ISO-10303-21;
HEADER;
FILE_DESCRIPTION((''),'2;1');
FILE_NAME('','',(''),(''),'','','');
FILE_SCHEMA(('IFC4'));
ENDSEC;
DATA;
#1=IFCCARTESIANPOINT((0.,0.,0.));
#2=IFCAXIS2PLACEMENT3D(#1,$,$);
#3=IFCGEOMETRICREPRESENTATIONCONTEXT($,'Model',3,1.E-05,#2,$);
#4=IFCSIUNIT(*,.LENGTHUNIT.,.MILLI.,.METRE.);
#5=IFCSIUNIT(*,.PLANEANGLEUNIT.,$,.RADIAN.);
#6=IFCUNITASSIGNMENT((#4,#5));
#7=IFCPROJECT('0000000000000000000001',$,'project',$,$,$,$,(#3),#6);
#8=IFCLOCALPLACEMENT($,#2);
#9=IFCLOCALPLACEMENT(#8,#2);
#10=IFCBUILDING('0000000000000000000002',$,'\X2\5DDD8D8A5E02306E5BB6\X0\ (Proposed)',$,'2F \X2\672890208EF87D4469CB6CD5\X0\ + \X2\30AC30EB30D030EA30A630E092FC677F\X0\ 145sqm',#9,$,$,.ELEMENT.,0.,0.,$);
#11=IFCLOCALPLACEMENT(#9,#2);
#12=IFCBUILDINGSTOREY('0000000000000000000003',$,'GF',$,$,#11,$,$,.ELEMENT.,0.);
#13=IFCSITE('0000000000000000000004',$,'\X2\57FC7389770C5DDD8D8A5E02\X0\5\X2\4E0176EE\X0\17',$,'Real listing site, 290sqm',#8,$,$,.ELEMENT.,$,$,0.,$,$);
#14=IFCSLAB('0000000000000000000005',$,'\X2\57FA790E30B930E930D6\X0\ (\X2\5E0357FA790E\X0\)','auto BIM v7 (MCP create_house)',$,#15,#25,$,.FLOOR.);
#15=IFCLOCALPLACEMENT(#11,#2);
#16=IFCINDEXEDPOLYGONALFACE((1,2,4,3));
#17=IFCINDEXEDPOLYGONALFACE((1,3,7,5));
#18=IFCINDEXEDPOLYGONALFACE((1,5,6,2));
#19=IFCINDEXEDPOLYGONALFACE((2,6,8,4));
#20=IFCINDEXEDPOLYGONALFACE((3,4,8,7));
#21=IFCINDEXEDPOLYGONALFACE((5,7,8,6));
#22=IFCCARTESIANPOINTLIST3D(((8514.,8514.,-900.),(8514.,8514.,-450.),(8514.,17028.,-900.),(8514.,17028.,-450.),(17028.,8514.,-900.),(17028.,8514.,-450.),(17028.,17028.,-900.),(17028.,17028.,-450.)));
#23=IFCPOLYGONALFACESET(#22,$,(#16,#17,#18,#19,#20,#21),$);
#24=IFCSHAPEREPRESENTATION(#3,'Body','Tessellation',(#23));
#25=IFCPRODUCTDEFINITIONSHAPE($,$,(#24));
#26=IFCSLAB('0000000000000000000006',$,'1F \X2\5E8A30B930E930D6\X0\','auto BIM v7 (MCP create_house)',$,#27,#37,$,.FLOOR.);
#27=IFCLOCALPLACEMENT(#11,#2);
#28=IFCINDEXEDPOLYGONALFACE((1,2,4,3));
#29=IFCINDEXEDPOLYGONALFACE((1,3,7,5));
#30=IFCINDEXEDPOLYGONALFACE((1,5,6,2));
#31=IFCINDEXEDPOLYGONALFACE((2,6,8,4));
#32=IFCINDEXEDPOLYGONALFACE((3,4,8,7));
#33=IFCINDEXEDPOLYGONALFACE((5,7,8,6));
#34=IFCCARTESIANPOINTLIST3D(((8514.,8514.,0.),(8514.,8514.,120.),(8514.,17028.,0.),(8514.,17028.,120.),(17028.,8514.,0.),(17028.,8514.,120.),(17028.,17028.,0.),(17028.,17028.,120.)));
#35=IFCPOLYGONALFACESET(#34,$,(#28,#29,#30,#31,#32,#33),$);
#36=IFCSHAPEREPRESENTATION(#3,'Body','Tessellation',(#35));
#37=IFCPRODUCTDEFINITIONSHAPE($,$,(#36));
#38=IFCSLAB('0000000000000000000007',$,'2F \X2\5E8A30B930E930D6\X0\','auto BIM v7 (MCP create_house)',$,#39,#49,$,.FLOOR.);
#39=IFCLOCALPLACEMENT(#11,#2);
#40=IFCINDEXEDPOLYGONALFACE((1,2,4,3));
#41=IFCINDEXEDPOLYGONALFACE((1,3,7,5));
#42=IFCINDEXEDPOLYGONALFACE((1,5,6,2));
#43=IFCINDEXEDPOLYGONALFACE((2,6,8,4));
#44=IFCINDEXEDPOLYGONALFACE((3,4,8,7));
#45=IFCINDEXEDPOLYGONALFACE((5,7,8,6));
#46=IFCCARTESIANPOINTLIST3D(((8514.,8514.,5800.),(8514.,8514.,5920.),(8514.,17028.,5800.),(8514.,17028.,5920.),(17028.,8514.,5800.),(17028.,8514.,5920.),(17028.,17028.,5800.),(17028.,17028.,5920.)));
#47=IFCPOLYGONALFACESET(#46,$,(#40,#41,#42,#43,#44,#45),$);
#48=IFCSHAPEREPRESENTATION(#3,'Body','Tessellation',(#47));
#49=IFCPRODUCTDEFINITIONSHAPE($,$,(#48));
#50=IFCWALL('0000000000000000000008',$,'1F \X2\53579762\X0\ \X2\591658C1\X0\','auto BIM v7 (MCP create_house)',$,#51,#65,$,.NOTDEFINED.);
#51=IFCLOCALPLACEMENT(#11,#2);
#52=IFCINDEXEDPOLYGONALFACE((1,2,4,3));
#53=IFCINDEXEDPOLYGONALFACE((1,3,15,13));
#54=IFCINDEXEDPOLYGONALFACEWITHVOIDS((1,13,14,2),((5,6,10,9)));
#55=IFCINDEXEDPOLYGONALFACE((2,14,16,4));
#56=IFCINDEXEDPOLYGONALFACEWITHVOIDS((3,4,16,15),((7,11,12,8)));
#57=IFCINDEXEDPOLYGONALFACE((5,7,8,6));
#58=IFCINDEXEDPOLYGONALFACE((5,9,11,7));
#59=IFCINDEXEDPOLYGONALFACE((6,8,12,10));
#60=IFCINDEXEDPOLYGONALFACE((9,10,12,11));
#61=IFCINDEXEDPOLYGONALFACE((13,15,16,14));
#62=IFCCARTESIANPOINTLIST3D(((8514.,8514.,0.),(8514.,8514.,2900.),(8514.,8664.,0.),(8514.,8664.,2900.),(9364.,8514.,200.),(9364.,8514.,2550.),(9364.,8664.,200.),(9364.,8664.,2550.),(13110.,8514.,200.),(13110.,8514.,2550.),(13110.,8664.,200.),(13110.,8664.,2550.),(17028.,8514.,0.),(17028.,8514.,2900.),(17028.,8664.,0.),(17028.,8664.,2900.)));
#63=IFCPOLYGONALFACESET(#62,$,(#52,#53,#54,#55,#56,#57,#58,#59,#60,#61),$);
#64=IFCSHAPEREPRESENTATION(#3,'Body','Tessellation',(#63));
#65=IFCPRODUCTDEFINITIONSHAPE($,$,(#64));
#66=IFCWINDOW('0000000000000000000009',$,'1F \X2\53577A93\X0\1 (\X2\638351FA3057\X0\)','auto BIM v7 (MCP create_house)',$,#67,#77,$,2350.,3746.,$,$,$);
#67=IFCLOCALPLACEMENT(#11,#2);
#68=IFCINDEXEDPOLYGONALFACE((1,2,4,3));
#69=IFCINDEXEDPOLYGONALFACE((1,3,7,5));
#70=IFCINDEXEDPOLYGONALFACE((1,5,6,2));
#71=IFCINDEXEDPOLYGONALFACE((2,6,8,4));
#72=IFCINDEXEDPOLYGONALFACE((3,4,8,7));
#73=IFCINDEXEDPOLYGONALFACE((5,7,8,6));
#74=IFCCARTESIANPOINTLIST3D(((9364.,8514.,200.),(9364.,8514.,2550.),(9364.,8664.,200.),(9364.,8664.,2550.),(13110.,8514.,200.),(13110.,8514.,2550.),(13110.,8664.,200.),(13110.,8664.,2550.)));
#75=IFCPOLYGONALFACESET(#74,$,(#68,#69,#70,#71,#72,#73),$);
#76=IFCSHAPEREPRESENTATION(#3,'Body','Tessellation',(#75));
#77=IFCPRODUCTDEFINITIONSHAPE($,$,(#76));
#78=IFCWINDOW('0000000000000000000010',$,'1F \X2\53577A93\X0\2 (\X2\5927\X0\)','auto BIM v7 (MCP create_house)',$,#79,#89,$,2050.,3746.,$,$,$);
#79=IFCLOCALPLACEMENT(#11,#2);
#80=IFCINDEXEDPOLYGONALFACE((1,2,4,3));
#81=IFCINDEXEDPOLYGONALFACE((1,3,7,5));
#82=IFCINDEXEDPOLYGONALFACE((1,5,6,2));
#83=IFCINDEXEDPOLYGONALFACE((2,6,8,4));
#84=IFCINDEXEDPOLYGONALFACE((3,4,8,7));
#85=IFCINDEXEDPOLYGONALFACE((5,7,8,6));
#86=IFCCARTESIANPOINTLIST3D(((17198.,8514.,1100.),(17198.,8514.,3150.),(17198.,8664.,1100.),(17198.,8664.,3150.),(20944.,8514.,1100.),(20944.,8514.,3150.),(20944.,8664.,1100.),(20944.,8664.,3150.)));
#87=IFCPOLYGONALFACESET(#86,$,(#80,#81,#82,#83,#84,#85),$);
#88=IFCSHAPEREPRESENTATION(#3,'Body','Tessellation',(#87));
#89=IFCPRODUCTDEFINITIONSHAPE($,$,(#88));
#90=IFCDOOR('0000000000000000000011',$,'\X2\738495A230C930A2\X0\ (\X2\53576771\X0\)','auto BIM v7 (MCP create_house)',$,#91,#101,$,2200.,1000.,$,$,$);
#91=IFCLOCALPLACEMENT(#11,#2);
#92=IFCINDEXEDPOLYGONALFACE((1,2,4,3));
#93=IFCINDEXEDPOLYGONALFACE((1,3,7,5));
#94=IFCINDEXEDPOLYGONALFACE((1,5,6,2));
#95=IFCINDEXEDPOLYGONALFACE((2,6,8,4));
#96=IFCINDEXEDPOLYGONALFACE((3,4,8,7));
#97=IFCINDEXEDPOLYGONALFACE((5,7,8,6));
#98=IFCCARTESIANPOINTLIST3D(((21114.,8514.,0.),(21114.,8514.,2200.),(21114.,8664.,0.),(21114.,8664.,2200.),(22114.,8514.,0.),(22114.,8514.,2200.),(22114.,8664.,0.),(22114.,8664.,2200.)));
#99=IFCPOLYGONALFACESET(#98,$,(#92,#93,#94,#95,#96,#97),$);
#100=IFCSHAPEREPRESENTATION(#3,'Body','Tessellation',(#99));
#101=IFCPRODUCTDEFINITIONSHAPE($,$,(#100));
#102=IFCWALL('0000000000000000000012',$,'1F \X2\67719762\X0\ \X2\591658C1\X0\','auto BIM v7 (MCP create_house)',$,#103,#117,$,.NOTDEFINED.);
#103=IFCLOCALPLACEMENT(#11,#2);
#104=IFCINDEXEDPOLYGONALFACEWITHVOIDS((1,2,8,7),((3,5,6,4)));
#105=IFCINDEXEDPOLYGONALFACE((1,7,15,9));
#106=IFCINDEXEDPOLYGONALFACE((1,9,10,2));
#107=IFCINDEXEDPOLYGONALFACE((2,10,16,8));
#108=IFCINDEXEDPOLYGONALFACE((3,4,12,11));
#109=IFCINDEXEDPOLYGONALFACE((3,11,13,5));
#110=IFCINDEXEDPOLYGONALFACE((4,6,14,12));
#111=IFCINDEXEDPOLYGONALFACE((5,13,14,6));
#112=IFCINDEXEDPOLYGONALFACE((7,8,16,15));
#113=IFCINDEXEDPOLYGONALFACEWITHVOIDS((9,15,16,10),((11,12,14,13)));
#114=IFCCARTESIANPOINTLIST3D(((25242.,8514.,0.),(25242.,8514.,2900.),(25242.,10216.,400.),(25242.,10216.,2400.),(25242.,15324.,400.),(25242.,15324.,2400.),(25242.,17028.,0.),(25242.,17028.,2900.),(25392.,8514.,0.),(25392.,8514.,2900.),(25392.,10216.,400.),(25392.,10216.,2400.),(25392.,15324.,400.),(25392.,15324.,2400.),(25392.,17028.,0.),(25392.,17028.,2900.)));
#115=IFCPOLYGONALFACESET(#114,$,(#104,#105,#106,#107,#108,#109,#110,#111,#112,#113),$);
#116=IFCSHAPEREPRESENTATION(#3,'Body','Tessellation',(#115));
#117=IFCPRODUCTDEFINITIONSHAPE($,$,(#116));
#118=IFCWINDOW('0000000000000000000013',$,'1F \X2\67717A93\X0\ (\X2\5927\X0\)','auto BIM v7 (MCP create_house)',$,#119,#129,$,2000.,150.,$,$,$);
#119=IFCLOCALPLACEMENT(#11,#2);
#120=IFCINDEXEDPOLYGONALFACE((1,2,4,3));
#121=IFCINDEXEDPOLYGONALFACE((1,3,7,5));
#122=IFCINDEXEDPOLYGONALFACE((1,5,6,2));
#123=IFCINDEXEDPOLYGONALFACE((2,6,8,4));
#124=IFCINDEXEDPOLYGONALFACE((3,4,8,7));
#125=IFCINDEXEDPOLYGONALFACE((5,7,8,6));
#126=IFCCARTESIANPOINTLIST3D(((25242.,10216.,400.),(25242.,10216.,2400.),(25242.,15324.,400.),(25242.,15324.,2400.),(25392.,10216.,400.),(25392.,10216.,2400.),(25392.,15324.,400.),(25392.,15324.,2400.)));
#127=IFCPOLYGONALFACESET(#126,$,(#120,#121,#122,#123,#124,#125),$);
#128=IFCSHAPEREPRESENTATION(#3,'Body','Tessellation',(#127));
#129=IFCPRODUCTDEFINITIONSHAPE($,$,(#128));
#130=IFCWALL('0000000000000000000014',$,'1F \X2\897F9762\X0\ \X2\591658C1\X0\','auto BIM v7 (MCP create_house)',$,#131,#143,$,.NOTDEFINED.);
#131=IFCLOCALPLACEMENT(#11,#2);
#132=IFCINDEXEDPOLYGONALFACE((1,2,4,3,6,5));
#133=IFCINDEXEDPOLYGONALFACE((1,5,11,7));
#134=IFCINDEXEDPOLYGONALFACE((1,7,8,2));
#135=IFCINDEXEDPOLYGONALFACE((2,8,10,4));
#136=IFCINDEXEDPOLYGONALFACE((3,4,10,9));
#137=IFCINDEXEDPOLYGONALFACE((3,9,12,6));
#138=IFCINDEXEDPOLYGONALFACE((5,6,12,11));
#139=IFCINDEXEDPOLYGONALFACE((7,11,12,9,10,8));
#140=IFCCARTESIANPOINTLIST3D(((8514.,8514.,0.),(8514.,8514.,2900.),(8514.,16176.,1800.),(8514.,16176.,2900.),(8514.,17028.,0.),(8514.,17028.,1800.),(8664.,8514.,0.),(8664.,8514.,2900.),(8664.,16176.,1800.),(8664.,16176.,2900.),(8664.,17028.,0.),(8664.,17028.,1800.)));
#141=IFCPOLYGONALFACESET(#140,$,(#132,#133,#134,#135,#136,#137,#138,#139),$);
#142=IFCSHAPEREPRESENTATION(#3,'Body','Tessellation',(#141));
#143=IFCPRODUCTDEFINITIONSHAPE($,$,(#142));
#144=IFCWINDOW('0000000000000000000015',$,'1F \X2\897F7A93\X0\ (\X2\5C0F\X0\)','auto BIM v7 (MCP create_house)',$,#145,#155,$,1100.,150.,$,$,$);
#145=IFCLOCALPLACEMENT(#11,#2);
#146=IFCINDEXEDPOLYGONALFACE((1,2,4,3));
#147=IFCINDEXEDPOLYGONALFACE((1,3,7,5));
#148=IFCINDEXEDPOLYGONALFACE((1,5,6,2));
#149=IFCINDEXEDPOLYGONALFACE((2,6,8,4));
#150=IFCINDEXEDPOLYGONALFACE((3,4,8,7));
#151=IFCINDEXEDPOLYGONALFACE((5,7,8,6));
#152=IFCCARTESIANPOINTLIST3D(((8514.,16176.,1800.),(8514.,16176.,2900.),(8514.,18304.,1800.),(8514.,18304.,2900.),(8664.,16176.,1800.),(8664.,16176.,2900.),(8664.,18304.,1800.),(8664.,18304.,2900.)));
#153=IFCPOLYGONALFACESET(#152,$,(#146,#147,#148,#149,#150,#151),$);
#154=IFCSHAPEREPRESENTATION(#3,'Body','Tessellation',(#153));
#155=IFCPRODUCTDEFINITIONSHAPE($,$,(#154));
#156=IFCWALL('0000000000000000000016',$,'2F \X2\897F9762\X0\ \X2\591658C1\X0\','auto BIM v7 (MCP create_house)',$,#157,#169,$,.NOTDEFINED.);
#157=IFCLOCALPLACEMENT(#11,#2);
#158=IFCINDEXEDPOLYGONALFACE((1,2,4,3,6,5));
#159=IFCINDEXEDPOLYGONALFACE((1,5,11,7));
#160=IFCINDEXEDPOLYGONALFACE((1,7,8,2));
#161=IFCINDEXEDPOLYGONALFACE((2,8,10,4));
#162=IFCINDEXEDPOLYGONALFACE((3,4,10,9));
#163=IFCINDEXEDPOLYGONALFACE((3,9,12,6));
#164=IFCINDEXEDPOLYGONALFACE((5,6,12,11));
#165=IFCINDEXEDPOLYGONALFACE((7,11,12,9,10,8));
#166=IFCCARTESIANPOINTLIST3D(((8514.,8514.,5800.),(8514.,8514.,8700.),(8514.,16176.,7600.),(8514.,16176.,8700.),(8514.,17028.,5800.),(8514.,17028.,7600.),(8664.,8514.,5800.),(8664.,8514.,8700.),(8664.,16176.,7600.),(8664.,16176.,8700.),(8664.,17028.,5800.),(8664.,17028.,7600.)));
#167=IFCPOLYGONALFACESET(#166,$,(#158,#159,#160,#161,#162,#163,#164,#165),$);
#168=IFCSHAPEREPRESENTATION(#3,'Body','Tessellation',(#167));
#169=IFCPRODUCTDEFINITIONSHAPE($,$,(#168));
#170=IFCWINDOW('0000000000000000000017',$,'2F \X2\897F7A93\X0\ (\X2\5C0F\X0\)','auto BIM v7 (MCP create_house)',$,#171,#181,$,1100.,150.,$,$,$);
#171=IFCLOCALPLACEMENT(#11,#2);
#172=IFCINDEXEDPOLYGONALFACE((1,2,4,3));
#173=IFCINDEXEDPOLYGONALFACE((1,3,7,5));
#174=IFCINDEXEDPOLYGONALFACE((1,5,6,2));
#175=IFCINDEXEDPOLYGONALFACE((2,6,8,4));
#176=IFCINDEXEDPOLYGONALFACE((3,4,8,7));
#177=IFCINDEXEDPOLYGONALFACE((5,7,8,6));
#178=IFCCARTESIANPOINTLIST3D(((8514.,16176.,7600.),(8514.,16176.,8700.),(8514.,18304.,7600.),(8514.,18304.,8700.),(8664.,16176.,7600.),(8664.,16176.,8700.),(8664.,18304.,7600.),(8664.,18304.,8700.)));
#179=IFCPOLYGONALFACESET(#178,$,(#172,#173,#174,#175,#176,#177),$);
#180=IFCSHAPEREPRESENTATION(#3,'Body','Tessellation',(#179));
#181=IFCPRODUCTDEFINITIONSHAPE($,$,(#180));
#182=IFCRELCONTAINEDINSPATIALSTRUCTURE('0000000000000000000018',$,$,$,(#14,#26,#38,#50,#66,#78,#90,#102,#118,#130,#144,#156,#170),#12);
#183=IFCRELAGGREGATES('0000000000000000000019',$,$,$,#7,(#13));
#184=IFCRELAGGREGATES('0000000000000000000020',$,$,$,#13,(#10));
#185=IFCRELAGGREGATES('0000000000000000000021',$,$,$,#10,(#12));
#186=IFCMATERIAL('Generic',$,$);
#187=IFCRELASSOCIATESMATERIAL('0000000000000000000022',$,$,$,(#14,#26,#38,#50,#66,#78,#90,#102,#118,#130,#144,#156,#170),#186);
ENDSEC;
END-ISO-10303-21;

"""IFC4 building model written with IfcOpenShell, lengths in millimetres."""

from ifc_helpers import new_model, si_unit, frame, frame_2d, origin, place, context, project, spatial, rectangle, extrude, material, element, fill, save


model = new_model("IFC4")

# Units and contexts
model_context = context("Model", 3, precision=1e-05, world=origin())
ifc_project = project(units=[si_unit("LENGTHUNIT", "METRE", prefix="MILLI"), si_unit("PLANEANGLEUNIT", "RADIAN")], contexts=[model_context])

# Site, building, storey
site_placement = place(None, origin())
site = spatial("IfcSite", under=ifc_project, at=site_placement, Name="埼玉県川越市5丁目17", ObjectType="Real listing site, 290sqm", CompositionType="ELEMENT", RefElevation=0.0)
building_placement = place(site_placement, origin())
building = spatial("IfcBuilding", under=site, at=building_placement, Name="川越市の家 (Proposed)", ObjectType="2F 木造軸組構法 + ガルバリウム鋼板 145sqm", CompositionType="ELEMENT", ElevationOfRefHeight=0.0, ElevationOfTerrain=0.0)
storey_placement = place(building_placement, origin())
storey = spatial("IfcBuildingStorey", under=building, at=storey_placement, Name="GF", CompositionType="ELEMENT", Elevation=0.0)

# Slabs
ifc_material = material(Name="Generic")
slab_1_placement = place(storey_placement, frame((4257.0, 4257.0, -450.0)))
element("IfcSlab", 1, at=slab_1_placement, inside=storey, material=ifc_material, Name="基礎スラブ (布基礎)", Description="auto BIM v7 (MCP create_house)", PredefinedType="FLOOR", context=model_context, shape_type="SweptSolid", body=[
    extrude(rectangle(XDim=8514.0, YDim=8514.0, at=frame_2d((4257.0, 4257.0))), frame((4257.0, 4257.0, -450.0)), (0.0, 0.0, 1.0), 450.0),
])
slab_2_placement = place(storey_placement, frame((4257.0, 4257.0, 0.0)))
element("IfcSlab", 2, at=slab_2_placement, inside=storey, material=ifc_material, Name="1F 床スラブ", Description="auto BIM v7 (MCP create_house)", PredefinedType="FLOOR", context=model_context, shape_type="SweptSolid", body=[
    extrude(rectangle(XDim=8514.0, YDim=8514.0, at=frame_2d((4257.0, 4257.0))), frame((4257.0, 4257.0, 0.0)), (0.0, 0.0, 1.0), 120.0),
])
slab_3_placement = place(storey_placement, frame((4257.0, 4257.0, 2900.0)))
element("IfcSlab", 3, at=slab_3_placement, inside=storey, material=ifc_material, Name="2F 床スラブ", Description="auto BIM v7 (MCP create_house)", PredefinedType="FLOOR", context=model_context, shape_type="SweptSolid", body=[
    extrude(rectangle(XDim=8514.0, YDim=8514.0, at=frame_2d((4257.0, 4257.0))), frame((4257.0, 4257.0, 2900.0)), (0.0, 0.0, 1.0), 120.0),
])

# Wall, openings, windows, door
wall_1_placement = place(storey_placement, frame((4257.0, 4257.0, 0.0)))
wall_1 = element("IfcWall", 4, at=wall_1_placement, inside=storey, material=ifc_material, Name="1F 南面 外壁", Description="auto BIM v7 (MCP create_house)", PredefinedType="NOTDEFINED", context=model_context, shape_type="SweptSolid", body=[
    extrude(rectangle(XDim=8514.0, YDim=150.0, at=frame_2d((4257.0, 75.0))), frame((4257.0, 4257.0, 0.0)), (0.0, 0.0, 1.0), 2900.0),
])
opening_1_placement = place(storey_placement, frame((4682.0, 4257.0, 100.0)))
opening_1 = element("IfcOpeningElement", 5, at=opening_1_placement, cuts=wall_1, PredefinedType="NOTDEFINED", context=model_context, shape_type="SweptSolid", body=[
    extrude(rectangle(XDim=3746.0, YDim=150.0, at=frame_2d((1873.0, 75.0))), frame((4682.0, 4257.0, 100.0)), (0.0, 0.0, 1.0), 2350.0),
])
opening_2_placement = place(storey_placement, frame((8599.0, 4257.0, 550.0)))
opening_2 = element("IfcOpeningElement", 6, at=opening_2_placement, cuts=wall_1, PredefinedType="NOTDEFINED", context=model_context, shape_type="SweptSolid", body=[
    extrude(rectangle(XDim=3746.0, YDim=150.0, at=frame_2d((1873.0, 75.0))), frame((8599.0, 4257.0, 550.0)), (0.0, 0.0, 1.0), 2050.0),
])
opening_3_placement = place(storey_placement, frame((10557.0, 4257.0, 0.0)))
opening_3 = element("IfcOpeningElement", 7, at=opening_3_placement, cuts=wall_1, PredefinedType="NOTDEFINED", context=model_context, shape_type="SweptSolid", body=[
    extrude(rectangle(XDim=1000.0, YDim=150.0, at=frame_2d((500.0, 75.0))), frame((10557.0, 4257.0, 0.0)), (0.0, 0.0, 1.0), 2200.0),
])
window_1_placement = place(storey_placement, frame((4682.0, 4257.0, 100.0)))
window_1 = element("IfcWindow", 8, at=window_1_placement, inside=storey, material=ifc_material, Name="1F 南窓1 (掃出し)", Description="auto BIM v7 (MCP create_house)", OverallHeight=2350.0, OverallWidth=3746.0, context=model_context, shape_type="SweptSolid", body=[
    extrude(rectangle(XDim=3746.0, YDim=150.0, at=frame_2d((1873.0, 75.0))), frame((4682.0, 4257.0, 100.0)), (0.0, 0.0, 1.0), 2350.0),
])
fill(opening_1, window_1)
window_2_placement = place(storey_placement, frame((8599.0, 4257.0, 550.0)))
window_2 = element("IfcWindow", 9, at=window_2_placement, inside=storey, material=ifc_material, Name="1F 南窓2 (大)", Description="auto BIM v7 (MCP create_house)", OverallHeight=2050.0, OverallWidth=3746.0, context=model_context, shape_type="SweptSolid", body=[
    extrude(rectangle(XDim=3746.0, YDim=150.0, at=frame_2d((1873.0, 75.0))), frame((8599.0, 4257.0, 550.0)), (0.0, 0.0, 1.0), 2050.0),
])
fill(opening_2, window_2)
door_placement = place(storey_placement, frame((10557.0, 4257.0, 0.0)))
door = element("IfcDoor", 10, at=door_placement, inside=storey, material=ifc_material, Name="玄関ドア (南東)", Description="auto BIM v7 (MCP create_house)", OverallHeight=2200.0, OverallWidth=1000.0, context=model_context, shape_type="SweptSolid", body=[
    extrude(rectangle(XDim=1000.0, YDim=150.0, at=frame_2d((500.0, 75.0))), frame((10557.0, 4257.0, 0.0)), (0.0, 0.0, 1.0), 2200.0),
])
fill(opening_3, door)

# Walls, openings, windows
wall_2_placement = place(storey_placement, frame((12621.0, 4257.0, 0.0)))
wall_2 = element("IfcWall", 11, at=wall_2_placement, inside=storey, material=ifc_material, Name="1F 東面 外壁", Description="auto BIM v7 (MCP create_house)", PredefinedType="NOTDEFINED", context=model_context, shape_type="SweptSolid", body=[
    extrude(rectangle(XDim=150.0, YDim=8514.0, at=frame_2d((75.0, 4257.0))), frame((12621.0, 4257.0, 0.0)), (0.0, 0.0, 1.0), 2900.0),
])
opening_4_placement = place(storey_placement, frame((12621.0, 5108.0, 200.0)))
opening_4 = element("IfcOpeningElement", 12, at=opening_4_placement, cuts=wall_2, PredefinedType="NOTDEFINED", context=model_context, shape_type="SweptSolid", body=[
    extrude(rectangle(XDim=150.0, YDim=5108.0, at=frame_2d((75.0, 2554.0))), frame((12621.0, 5108.0, 200.0)), (0.0, 0.0, 1.0), 2000.0),
])
window_3_placement = place(storey_placement, frame((12621.0, 5108.0, 200.0)))
window_3 = element("IfcWindow", 13, at=window_3_placement, inside=storey, material=ifc_material, Name="1F 東窓 (大)", Description="auto BIM v7 (MCP create_house)", OverallHeight=2000.0, OverallWidth=150.0, context=model_context, shape_type="SweptSolid", body=[
    extrude(rectangle(XDim=150.0, YDim=5108.0, at=frame_2d((75.0, 2554.0))), frame((12621.0, 5108.0, 200.0)), (0.0, 0.0, 1.0), 2000.0),
])
fill(opening_4, window_3)
wall_3_placement = place(storey_placement, frame((4257.0, 4257.0, 0.0)))
wall_3 = element("IfcWall", 14, at=wall_3_placement, inside=storey, material=ifc_material, Name="1F 西面 外壁", Description="auto BIM v7 (MCP create_house)", PredefinedType="NOTDEFINED", context=model_context, shape_type="SweptSolid", body=[
    extrude(rectangle(XDim=150.0, YDim=8514.0, at=frame_2d((75.0, 4257.0))), frame((4257.0, 4257.0, 0.0)), (0.0, 0.0, 1.0), 2900.0),
])
opening_5_placement = place(storey_placement, frame((4257.0, 8088.0, 900.0)))
opening_5 = element("IfcOpeningElement", 15, at=opening_5_placement, cuts=wall_3, PredefinedType="NOTDEFINED", context=model_context, shape_type="SweptSolid", body=[
    extrude(rectangle(XDim=150.0, YDim=2128.0, at=frame_2d((75.0, 1064.0))), frame((4257.0, 8088.0, 900.0)), (0.0, 0.0, 1.0), 1100.0),
])
window_4_placement = place(storey_placement, frame((4257.0, 8088.0, 900.0)))
window_4 = element("IfcWindow", 16, at=window_4_placement, inside=storey, material=ifc_material, Name="1F 西窓 (小)", Description="auto BIM v7 (MCP create_house)", OverallHeight=1100.0, OverallWidth=150.0, context=model_context, shape_type="SweptSolid", body=[
    extrude(rectangle(XDim=150.0, YDim=2128.0, at=frame_2d((75.0, 1064.0))), frame((4257.0, 8088.0, 900.0)), (0.0, 0.0, 1.0), 1100.0),
])
fill(opening_5, window_4)

# Wall, opening, window
wall_4_placement = place(storey_placement, frame((4257.0, 4257.0, 2900.0)))
wall_4 = element("IfcWall", 17, at=wall_4_placement, inside=storey, material=ifc_material, Name="2F 西面 外壁", Description="auto BIM v7 (MCP create_house)", PredefinedType="NOTDEFINED", context=model_context, shape_type="SweptSolid", body=[
    extrude(rectangle(XDim=150.0, YDim=8514.0, at=frame_2d((75.0, 4257.0))), frame((4257.0, 4257.0, 2900.0)), (0.0, 0.0, 1.0), 2900.0),
])
opening_6_placement = place(storey_placement, frame((4257.0, 8088.0, 3800.0)))
opening_6 = element("IfcOpeningElement", 18, at=opening_6_placement, cuts=wall_4, PredefinedType="NOTDEFINED", context=model_context, shape_type="SweptSolid", body=[
    extrude(rectangle(XDim=150.0, YDim=2128.0, at=frame_2d((75.0, 1064.0))), frame((4257.0, 8088.0, 3800.0)), (0.0, 0.0, 1.0), 1100.0),
])
window_5_placement = place(storey_placement, frame((4257.0, 8088.0, 3800.0)))
window_5 = element("IfcWindow", 19, at=window_5_placement, inside=storey, material=ifc_material, Name="2F 西窓 (小)", Description="auto BIM v7 (MCP create_house)", OverallHeight=1100.0, OverallWidth=150.0, context=model_context, shape_type="SweptSolid", body=[
    extrude(rectangle(XDim=150.0, YDim=2128.0, at=frame_2d((75.0, 1064.0))), frame((4257.0, 8088.0, 3800.0)), (0.0, 0.0, 1.0), 1100.0),
])
fill(opening_6, window_5)

save(model, "model.ifc")
